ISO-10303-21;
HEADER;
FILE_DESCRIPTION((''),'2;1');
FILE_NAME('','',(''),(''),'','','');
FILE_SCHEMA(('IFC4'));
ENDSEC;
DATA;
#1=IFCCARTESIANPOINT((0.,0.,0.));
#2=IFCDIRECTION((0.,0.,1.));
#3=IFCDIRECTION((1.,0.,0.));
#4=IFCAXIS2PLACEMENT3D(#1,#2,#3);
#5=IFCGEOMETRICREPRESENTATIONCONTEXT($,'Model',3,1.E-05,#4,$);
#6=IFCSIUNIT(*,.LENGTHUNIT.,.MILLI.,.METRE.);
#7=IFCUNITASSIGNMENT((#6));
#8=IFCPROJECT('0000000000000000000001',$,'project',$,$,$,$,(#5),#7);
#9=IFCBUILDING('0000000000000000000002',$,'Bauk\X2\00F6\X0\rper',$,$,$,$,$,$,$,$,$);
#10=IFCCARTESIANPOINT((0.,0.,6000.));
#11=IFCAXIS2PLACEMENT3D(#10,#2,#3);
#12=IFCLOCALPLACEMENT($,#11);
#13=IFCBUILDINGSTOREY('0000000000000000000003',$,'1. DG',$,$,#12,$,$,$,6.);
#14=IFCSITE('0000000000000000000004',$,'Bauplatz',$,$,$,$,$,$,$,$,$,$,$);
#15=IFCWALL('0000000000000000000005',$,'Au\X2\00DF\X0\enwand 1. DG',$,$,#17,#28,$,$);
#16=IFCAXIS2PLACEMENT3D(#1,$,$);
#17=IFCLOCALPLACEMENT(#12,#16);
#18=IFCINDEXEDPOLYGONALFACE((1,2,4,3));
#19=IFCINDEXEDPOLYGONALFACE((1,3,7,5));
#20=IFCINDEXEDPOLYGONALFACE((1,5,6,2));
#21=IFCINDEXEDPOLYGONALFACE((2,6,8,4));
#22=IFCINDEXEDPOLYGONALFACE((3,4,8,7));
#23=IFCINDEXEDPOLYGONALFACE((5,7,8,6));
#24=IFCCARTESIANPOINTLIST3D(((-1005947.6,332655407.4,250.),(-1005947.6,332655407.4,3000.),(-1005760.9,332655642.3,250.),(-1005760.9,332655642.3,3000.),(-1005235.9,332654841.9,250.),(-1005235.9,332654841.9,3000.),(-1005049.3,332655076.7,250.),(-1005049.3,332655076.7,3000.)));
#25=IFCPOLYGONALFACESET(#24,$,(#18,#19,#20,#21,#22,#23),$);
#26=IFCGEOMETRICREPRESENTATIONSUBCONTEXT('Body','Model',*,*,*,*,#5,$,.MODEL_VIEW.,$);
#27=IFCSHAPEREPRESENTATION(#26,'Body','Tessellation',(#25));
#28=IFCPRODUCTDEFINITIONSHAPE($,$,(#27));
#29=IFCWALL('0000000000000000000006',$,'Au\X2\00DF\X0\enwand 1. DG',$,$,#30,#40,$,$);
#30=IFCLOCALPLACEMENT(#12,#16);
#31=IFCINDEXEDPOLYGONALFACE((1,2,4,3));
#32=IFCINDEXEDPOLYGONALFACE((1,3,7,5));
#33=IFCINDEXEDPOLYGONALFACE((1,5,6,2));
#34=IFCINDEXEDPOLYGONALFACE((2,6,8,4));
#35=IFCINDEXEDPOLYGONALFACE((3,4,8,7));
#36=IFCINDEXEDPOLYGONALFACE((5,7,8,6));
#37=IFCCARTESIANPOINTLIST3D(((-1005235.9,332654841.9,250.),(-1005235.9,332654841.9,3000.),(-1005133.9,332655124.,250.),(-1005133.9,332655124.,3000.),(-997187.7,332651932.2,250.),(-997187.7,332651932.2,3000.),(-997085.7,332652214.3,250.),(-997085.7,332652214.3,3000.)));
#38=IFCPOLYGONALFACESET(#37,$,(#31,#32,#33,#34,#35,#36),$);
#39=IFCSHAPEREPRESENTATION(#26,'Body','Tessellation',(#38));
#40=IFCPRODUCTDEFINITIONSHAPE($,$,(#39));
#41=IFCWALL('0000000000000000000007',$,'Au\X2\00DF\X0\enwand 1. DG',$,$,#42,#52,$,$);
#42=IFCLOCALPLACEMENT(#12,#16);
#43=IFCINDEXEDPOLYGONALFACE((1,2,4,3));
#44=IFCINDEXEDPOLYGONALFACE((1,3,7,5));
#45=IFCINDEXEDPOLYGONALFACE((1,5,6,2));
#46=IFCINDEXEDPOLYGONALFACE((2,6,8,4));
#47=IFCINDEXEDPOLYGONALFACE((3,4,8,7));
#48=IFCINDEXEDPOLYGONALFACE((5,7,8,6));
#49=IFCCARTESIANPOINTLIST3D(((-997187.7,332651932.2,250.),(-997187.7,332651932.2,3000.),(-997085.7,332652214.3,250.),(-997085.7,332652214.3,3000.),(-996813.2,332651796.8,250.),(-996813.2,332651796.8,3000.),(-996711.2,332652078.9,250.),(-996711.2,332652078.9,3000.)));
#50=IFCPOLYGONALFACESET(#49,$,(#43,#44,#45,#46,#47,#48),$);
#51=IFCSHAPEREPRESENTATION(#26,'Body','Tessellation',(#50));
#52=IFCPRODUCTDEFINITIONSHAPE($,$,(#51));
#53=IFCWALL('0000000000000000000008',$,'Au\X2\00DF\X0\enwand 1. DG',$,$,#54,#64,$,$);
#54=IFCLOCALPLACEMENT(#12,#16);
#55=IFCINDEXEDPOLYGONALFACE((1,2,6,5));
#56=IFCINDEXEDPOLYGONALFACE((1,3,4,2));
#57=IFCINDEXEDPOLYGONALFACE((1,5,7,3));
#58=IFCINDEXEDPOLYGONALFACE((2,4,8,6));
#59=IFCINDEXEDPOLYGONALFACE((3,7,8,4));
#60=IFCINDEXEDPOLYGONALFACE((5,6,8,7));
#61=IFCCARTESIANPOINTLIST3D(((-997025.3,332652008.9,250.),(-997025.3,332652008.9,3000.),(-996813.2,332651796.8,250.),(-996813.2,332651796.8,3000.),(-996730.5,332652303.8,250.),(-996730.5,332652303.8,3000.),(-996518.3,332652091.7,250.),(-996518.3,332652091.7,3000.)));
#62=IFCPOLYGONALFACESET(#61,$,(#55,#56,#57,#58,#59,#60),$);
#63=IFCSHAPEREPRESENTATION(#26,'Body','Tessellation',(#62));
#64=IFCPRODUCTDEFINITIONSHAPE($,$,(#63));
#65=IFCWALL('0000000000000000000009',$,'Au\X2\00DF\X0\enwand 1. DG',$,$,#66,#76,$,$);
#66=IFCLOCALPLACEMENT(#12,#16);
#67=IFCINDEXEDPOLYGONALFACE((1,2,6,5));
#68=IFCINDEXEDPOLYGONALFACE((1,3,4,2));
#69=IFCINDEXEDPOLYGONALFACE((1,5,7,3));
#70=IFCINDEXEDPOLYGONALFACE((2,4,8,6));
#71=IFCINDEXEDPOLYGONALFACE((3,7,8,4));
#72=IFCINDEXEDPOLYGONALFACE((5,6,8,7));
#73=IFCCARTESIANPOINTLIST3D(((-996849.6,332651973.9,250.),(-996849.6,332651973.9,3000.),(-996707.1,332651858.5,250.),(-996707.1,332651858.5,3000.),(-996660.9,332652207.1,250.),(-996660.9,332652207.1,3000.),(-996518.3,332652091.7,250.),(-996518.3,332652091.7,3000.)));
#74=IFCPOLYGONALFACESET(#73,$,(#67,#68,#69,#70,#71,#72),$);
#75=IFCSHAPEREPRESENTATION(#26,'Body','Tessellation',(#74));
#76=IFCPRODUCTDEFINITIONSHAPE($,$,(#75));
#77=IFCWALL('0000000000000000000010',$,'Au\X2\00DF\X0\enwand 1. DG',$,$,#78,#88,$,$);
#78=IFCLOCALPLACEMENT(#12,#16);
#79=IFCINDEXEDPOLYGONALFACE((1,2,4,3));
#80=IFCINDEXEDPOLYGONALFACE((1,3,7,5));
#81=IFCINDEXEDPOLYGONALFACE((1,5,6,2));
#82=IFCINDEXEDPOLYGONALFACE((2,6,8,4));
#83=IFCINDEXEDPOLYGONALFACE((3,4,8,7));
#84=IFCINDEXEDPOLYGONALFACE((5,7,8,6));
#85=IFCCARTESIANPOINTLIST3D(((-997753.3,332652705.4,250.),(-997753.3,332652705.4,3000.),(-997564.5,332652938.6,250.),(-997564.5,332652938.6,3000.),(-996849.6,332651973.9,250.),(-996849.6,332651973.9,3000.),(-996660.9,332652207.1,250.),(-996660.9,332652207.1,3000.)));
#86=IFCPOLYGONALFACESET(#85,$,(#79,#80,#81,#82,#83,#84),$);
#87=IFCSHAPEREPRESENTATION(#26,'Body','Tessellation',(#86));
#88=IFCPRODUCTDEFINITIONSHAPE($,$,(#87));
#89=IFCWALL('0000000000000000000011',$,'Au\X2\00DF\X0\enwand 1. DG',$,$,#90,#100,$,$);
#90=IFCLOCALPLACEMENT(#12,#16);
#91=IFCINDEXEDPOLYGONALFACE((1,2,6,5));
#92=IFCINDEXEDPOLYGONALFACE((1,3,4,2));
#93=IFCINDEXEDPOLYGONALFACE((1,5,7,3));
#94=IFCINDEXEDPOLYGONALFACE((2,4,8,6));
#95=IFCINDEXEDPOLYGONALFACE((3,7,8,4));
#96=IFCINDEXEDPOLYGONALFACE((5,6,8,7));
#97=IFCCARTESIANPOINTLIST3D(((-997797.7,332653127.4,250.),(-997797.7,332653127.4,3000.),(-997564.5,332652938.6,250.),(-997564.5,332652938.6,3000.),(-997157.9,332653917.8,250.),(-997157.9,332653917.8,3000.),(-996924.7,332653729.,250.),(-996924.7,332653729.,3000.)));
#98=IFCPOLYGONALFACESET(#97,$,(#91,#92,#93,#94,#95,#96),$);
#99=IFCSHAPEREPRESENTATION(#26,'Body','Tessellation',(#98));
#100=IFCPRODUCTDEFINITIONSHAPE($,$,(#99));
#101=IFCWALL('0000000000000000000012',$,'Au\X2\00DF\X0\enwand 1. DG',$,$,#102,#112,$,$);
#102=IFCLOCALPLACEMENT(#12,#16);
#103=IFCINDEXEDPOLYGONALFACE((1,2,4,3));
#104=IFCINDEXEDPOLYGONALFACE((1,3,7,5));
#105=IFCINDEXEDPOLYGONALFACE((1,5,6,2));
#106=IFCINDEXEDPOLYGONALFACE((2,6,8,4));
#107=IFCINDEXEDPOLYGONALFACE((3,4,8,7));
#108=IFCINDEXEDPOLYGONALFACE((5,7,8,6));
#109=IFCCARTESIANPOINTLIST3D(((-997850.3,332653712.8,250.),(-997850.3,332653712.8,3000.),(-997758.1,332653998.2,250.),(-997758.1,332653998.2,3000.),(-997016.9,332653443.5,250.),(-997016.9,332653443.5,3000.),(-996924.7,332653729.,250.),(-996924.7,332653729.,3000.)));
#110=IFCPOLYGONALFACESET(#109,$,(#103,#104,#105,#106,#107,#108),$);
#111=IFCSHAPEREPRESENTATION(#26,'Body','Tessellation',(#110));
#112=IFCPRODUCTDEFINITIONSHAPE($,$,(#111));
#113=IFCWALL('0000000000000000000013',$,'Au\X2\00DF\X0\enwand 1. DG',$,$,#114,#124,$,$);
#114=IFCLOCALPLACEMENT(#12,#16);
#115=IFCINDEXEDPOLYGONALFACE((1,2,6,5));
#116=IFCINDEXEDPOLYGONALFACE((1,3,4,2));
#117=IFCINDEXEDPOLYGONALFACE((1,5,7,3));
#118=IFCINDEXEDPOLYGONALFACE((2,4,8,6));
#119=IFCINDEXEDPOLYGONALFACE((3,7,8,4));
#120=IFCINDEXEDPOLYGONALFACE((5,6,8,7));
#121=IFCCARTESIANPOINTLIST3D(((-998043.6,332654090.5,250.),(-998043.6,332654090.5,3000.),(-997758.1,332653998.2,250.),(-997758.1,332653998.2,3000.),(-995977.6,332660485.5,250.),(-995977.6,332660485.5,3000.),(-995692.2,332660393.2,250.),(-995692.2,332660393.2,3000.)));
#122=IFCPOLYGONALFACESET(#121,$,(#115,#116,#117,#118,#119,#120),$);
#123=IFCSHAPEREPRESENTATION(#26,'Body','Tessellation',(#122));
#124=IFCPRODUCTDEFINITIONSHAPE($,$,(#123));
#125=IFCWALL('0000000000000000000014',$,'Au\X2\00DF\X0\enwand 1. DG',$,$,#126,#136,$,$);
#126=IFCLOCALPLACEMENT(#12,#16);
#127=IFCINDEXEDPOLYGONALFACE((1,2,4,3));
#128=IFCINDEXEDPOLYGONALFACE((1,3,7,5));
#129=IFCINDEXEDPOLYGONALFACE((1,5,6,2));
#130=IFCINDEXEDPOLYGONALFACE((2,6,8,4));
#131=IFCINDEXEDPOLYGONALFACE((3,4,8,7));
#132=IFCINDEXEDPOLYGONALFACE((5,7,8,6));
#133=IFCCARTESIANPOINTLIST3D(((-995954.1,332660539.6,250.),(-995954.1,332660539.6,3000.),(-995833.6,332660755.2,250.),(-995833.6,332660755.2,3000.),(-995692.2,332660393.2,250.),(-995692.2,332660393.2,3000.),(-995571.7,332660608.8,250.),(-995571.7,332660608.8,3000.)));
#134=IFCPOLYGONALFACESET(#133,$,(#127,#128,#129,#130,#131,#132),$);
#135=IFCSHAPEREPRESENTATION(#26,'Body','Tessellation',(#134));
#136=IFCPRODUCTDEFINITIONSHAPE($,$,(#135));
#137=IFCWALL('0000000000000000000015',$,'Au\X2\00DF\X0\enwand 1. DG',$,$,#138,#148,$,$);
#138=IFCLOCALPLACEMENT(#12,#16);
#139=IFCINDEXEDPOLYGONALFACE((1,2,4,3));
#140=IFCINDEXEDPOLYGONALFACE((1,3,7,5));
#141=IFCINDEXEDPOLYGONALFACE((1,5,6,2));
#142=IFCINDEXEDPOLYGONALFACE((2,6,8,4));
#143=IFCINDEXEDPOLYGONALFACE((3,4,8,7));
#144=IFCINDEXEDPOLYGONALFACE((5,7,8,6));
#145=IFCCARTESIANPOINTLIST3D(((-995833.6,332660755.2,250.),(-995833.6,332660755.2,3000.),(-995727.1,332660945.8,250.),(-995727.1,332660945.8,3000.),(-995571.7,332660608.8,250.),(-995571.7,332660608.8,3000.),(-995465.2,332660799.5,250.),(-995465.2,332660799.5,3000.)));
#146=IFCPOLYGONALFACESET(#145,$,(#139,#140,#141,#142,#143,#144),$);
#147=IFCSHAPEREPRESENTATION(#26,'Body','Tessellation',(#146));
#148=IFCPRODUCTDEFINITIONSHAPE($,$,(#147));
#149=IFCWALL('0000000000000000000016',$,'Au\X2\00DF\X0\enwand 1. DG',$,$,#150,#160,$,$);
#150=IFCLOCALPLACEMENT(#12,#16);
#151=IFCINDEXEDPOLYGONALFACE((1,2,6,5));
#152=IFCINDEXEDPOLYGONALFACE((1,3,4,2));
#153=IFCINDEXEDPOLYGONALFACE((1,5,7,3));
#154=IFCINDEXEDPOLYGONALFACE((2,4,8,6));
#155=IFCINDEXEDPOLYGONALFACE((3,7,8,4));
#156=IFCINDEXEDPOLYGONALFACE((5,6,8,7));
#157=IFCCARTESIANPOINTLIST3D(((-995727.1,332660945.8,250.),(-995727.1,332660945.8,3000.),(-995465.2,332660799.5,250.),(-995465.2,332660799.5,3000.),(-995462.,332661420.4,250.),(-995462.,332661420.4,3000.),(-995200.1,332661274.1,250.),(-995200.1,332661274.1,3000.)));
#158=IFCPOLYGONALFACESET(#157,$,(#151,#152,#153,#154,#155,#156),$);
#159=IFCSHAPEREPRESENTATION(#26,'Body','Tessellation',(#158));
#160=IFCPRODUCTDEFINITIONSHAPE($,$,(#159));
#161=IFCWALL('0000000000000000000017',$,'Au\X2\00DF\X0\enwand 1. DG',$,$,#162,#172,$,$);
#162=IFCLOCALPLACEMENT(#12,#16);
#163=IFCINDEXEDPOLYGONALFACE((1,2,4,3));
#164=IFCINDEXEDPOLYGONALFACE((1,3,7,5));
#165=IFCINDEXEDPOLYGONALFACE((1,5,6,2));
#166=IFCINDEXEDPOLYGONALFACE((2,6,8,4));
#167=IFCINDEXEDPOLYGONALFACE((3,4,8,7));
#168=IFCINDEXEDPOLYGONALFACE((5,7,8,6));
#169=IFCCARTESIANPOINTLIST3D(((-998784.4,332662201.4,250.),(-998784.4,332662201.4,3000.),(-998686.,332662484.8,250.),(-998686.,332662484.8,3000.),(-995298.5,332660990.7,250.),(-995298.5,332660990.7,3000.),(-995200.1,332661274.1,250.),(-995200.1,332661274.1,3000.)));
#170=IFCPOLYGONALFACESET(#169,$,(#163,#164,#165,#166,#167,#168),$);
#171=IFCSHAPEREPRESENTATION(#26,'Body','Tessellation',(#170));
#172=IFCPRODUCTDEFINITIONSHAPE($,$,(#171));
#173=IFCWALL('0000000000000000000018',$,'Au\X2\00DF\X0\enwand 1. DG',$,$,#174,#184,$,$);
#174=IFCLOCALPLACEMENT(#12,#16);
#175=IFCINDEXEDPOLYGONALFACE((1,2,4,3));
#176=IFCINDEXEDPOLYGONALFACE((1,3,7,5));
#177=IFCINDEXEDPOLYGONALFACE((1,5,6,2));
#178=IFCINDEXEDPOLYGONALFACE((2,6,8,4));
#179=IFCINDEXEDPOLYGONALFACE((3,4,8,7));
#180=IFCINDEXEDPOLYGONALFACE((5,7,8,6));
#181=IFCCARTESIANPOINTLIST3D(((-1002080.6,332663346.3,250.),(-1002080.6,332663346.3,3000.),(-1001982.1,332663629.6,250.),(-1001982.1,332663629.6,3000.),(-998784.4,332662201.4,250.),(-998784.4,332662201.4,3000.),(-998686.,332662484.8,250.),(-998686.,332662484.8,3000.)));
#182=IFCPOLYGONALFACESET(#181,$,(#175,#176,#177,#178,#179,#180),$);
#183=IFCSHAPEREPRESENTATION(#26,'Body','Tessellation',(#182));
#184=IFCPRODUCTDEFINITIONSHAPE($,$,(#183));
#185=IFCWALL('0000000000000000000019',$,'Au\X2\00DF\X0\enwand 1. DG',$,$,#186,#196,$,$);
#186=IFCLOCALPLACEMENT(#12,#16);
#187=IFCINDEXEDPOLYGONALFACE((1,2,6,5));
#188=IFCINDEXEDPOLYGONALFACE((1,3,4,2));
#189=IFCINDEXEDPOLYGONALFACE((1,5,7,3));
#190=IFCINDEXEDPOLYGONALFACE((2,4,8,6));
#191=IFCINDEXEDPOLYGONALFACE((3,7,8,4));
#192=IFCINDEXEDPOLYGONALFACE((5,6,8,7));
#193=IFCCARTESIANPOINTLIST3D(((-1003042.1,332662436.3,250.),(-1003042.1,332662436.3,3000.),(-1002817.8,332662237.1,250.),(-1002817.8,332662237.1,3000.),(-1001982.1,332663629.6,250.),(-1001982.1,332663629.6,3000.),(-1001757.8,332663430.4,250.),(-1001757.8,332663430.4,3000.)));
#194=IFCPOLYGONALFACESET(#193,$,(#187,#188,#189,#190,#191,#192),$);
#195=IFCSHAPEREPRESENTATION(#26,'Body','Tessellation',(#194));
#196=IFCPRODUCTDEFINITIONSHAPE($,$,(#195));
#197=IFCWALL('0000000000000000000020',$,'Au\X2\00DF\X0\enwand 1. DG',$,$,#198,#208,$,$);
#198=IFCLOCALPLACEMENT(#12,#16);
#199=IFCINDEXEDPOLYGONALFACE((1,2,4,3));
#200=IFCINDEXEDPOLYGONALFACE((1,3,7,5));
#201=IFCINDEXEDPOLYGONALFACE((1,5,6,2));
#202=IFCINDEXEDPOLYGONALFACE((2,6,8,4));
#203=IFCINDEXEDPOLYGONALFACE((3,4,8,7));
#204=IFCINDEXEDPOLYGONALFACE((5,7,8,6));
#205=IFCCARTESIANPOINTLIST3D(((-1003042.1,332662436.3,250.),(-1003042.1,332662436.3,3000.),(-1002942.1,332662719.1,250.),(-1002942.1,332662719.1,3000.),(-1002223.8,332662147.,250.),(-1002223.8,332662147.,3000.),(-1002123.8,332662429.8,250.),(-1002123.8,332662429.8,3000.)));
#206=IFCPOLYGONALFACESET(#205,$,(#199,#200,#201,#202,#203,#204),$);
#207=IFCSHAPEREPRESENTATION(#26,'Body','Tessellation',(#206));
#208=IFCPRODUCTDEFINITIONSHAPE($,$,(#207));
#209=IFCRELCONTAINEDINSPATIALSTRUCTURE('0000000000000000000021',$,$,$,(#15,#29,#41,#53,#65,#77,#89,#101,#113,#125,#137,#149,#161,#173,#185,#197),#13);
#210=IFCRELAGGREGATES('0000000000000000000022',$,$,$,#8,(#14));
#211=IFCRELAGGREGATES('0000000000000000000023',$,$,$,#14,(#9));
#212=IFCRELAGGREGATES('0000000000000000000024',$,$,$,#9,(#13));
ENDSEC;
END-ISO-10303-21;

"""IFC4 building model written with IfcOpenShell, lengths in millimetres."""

from ifc_helpers import new_model, si_unit, frame, origin_with_axes, place, context, subcontext, project, spatial, indexed_curve, outline, extrude, element, save


model = new_model("IFC4")

# Units and contexts
model_context = context("Model", 3, precision=1e-05, world=origin_with_axes())
body_context = subcontext(model_context, "Body", "Model", "MODEL_VIEW")
ifc_project = project(units=[si_unit("LENGTHUNIT", "METRE", prefix="MILLI")], contexts=[model_context])

# Site, building, storey
site = spatial("IfcSite", under=ifc_project, Name="Bauplatz")
building = spatial("IfcBuilding", under=site, Name="Baukörper")
storey_placement = place(None, frame((0.0, 0.0, 6000.0), z_axis=(0.0, 0.0, 1.0), x_axis=(1.0, 0.0, 0.0)))
storey = spatial("IfcBuildingStorey", under=building, at=storey_placement, Name="1. DG", Elevation=6.0)

# Walls
wall_1_placement = place(storey_placement, frame((-1005947.6, 332655407.4, 250.0), z_axis=(0.0, 0.0, 1.0), x_axis=(0.782875, -0.622179, 0.0)))
element("IfcWall", 1, at=wall_1_placement, inside=storey, Name="Außenwand 1. DG", context=body_context, shape_type="SweptSolid", body=[
    extrude(outline(indexed_curve([(0.0, 0.0), (0.0, 300.0), (909.0, 300.0), (909.0, 0.0), (0.0, 0.0)], self_intersect=False)), origin_with_axes(), (0.0, 0.0, 1.0), 2750.0),
])
wall_2_placement = place(storey_placement, frame((-1005235.9, 332654841.9, 250.0), z_axis=(0.0, 0.0, 1.0), x_axis=(0.940428, -0.339993, 0.0)))
element("IfcWall", 2, at=wall_2_placement, inside=storey, Name="Außenwand 1. DG", context=body_context, shape_type="SweptSolid", body=[
    extrude(outline(indexed_curve([(0.0, 0.0), (0.0, 300.0), (8558.0, 300.0), (8558.0, 0.0), (0.0, 0.0)], self_intersect=False)), origin_with_axes(), (0.0, 0.0, 1.0), 2750.0),
])
wall_3_placement = place(storey_placement, frame((-997187.7, 332651932.2, 250.0), z_axis=(0.0, 0.0, 1.0), x_axis=(0.940428, -0.339993, 0.0)))
element("IfcWall", 3, at=wall_3_placement, inside=storey, Name="Außenwand 1. DG", context=body_context, shape_type="SweptSolid", body=[
    extrude(outline(indexed_curve([(0.0, 0.0), (0.0, 300.0), (398.3, 300.0), (398.3, 0.0), (0.0, 0.0)], self_intersect=False)), origin_with_axes(), (0.0, 0.0, 1.0), 2750.0),
])
wall_4_placement = place(storey_placement, frame((-996813.2, 332651796.8, 250.0), z_axis=(0.0, 0.0, 1.0), x_axis=(0.707107, 0.707107, 0.0)))
element("IfcWall", 4, at=wall_4_placement, inside=storey, Name="Außenwand 1. DG", context=body_context, shape_type="SweptSolid", body=[
    extrude(outline(indexed_curve([(0.0, 0.0), (0.0, 300.0), (417.0, 300.0), (417.0, 0.0), (0.0, 0.0)], self_intersect=False)), origin_with_axes(), (0.0, 0.0, 1.0), 2750.0),
])
wall_5_placement = place(storey_placement, frame((-996518.3, 332652091.7, 250.0), z_axis=(0.0, 0.0, 1.0), x_axis=(-0.777245, 0.629198, 0.0)))
element("IfcWall", 5, at=wall_5_placement, inside=storey, Name="Außenwand 1. DG", context=body_context, shape_type="SweptSolid", body=[
    extrude(outline(indexed_curve([(0.0, 0.0), (0.0, 300.0), (183.4, 300.0), (183.4, 0.0), (0.0, 0.0)], self_intersect=False)), origin_with_axes(), (0.0, 0.0, 1.0), 2750.0),
])
wall_6_placement = place(storey_placement, frame((-996660.9, 332652207.1, 250.0), z_axis=(0.0, 0.0, 1.0), x_axis=(-0.777245, 0.629198, 0.0)))
element("IfcWall", 6, at=wall_6_placement, inside=storey, Name="Außenwand 1. DG", context=body_context, shape_type="SweptSolid", body=[
    extrude(outline(indexed_curve([(0.0, 0.0), (0.0, 300.0), (1162.6, 300.0), (1162.6, 0.0), (0.0, 0.0)], self_intersect=False)), origin_with_axes(), (0.0, 0.0, 1.0), 2750.0),
])
wall_7_placement = place(storey_placement, frame((-997564.5, 332652938.6, 250.0), z_axis=(0.0, 0.0, 1.0), x_axis=(0.629198, 0.777245, 0.0)))
element("IfcWall", 7, at=wall_7_placement, inside=storey, Name="Außenwand 1. DG", context=body_context, shape_type="SweptSolid", body=[
    extrude(outline(indexed_curve([(0.0, 0.0), (0.0, 300.0), (1016.9, 300.0), (1016.9, 0.0), (0.0, 0.0)], self_intersect=False)), origin_with_axes(), (0.0, 0.0, 1.0), 2750.0),
])
wall_8_placement = place(storey_placement, frame((-996924.7, 332653729.0, 250.0), z_axis=(0.0, 0.0, 1.0), x_axis=(-0.951578, 0.307409, 0.0)))
element("IfcWall", 8, at=wall_8_placement, inside=storey, Name="Außenwand 1. DG", context=body_context, shape_type="SweptSolid", body=[
    extrude(outline(indexed_curve([(0.0, 0.0), (0.0, 300.0), (875.8, 300.0), (875.8, 0.0), (0.0, 0.0)], self_intersect=False)), origin_with_axes(), (0.0, 0.0, 1.0), 2750.0),
])
wall_9_placement = place(storey_placement, frame((-997758.1, 332653998.2, 250.0), z_axis=(0.0, 0.0, 1.0), x_axis=(0.307409, 0.951577, 0.0)))
element("IfcWall", 9, at=wall_9_placement, inside=storey, Name="Außenwand 1. DG", context=body_context, shape_type="SweptSolid", body=[
    extrude(outline(indexed_curve([(0.0, 0.0), (0.0, 300.0), (6720.4, 300.0), (6720.4, 0.0), (0.0, 0.0)], self_intersect=False)), origin_with_axes(), (0.0, 0.0, 1.0), 2750.0),
])
wall_10_placement = place(storey_placement, frame((-995692.2, 332660393.2, 250.0), z_axis=(0.0, 0.0, 1.0), x_axis=(0.487711, 0.873005, 0.0)))
element("IfcWall", 10, at=wall_10_placement, inside=storey, Name="Außenwand 1. DG", context=body_context, shape_type="SweptSolid", body=[
    extrude(outline(indexed_curve([(0.0, 0.0), (0.0, 300.0), (247.0, 300.0), (247.0, 0.0), (0.0, 0.0)], self_intersect=False)), origin_with_axes(), (0.0, 0.0, 1.0), 2750.0),
])
wall_11_placement = place(storey_placement, frame((-995571.7, 332660608.8, 250.0), z_axis=(0.0, 0.0, 1.0), x_axis=(0.487712, 0.873005, 0.0)))
element("IfcWall", 11, at=wall_11_placement, inside=storey, Name="Außenwand 1. DG", context=body_context, shape_type="SweptSolid", body=[
    extrude(outline(indexed_curve([(0.0, 0.0), (0.0, 300.0), (218.4, 300.0), (218.4, 0.0), (0.0, 0.0)], self_intersect=False)), origin_with_axes(), (0.0, 0.0, 1.0), 2750.0),
])
wall_12_placement = place(storey_placement, frame((-995465.2, 332660799.5, 250.0), z_axis=(0.0, 0.0, 1.0), x_axis=(0.487711, 0.873005, 0.0)))
element("IfcWall", 12, at=wall_12_placement, inside=storey, Name="Außenwand 1. DG", context=body_context, shape_type="SweptSolid", body=[
    extrude(outline(indexed_curve([(0.0, 0.0), (0.0, 300.0), (543.6, 300.0), (543.6, 0.0), (0.0, 0.0)], self_intersect=False)), origin_with_axes(), (0.0, 0.0, 1.0), 2750.0),
])
wall_13_placement = place(storey_placement, frame((-995200.1, 332661274.1, 250.0), z_axis=(0.0, 0.0, 1.0), x_axis=(-0.944643, 0.328101, 0.0)))
element("IfcWall", 13, at=wall_13_placement, inside=storey, Name="Außenwand 1. DG", context=body_context, shape_type="SweptSolid", body=[
    extrude(outline(indexed_curve([(0.0, 0.0), (0.0, 300.0), (3690.2, 300.0), (3690.2, 0.0), (0.0, 0.0)], self_intersect=False)), origin_with_axes(), (0.0, 0.0, 1.0), 2750.0),
])
wall_14_placement = place(storey_placement, frame((-998686.0, 332662484.8, 250.0), z_axis=(0.0, 0.0, 1.0), x_axis=(-0.944643, 0.328101, 0.0)))
element("IfcWall", 14, at=wall_14_placement, inside=storey, Name="Außenwand 1. DG", context=body_context, shape_type="SweptSolid", body=[
    extrude(outline(indexed_curve([(0.0, 0.0), (0.0, 300.0), (3489.3, 300.0), (3489.3, 0.0), (0.0, 0.0)], self_intersect=False)), origin_with_axes(), (0.0, 0.0, 1.0), 2750.0),
])
wall_15_placement = place(storey_placement, frame((-1001982.1, 332663629.6, 250.0), z_axis=(0.0, 0.0, 1.0), x_axis=(-0.664091, -0.747652, 0.0)))
element("IfcWall", 15, at=wall_15_placement, inside=storey, Name="Außenwand 1. DG", context=body_context, shape_type="SweptSolid", body=[
    extrude(outline(indexed_curve([(0.0, 0.0), (0.0, 300.0), (1596.2, 300.0), (1596.2, 0.0), (0.0, 0.0)], self_intersect=False)), origin_with_axes(), (0.0, 0.0, 1.0), 2750.0),
])
wall_16_placement = place(storey_placement, frame((-1003042.1, 332662436.3, 250.0), z_axis=(0.0, 0.0, 1.0), x_axis=(0.94281, -0.333331, 0.0)))
element("IfcWall", 16, at=wall_16_placement, inside=storey, Name="Außenwand 1. DG", context=body_context, shape_type="SweptSolid", body=[
    extrude(outline(indexed_curve([(0.0, 0.0), (0.0, 300.0), (867.9, 300.0), (867.9, 0.0), (0.0, 0.0)], self_intersect=False)), origin_with_axes(), (0.0, 0.0, 1.0), 2750.0),
])

save(model, "model.ifc")
